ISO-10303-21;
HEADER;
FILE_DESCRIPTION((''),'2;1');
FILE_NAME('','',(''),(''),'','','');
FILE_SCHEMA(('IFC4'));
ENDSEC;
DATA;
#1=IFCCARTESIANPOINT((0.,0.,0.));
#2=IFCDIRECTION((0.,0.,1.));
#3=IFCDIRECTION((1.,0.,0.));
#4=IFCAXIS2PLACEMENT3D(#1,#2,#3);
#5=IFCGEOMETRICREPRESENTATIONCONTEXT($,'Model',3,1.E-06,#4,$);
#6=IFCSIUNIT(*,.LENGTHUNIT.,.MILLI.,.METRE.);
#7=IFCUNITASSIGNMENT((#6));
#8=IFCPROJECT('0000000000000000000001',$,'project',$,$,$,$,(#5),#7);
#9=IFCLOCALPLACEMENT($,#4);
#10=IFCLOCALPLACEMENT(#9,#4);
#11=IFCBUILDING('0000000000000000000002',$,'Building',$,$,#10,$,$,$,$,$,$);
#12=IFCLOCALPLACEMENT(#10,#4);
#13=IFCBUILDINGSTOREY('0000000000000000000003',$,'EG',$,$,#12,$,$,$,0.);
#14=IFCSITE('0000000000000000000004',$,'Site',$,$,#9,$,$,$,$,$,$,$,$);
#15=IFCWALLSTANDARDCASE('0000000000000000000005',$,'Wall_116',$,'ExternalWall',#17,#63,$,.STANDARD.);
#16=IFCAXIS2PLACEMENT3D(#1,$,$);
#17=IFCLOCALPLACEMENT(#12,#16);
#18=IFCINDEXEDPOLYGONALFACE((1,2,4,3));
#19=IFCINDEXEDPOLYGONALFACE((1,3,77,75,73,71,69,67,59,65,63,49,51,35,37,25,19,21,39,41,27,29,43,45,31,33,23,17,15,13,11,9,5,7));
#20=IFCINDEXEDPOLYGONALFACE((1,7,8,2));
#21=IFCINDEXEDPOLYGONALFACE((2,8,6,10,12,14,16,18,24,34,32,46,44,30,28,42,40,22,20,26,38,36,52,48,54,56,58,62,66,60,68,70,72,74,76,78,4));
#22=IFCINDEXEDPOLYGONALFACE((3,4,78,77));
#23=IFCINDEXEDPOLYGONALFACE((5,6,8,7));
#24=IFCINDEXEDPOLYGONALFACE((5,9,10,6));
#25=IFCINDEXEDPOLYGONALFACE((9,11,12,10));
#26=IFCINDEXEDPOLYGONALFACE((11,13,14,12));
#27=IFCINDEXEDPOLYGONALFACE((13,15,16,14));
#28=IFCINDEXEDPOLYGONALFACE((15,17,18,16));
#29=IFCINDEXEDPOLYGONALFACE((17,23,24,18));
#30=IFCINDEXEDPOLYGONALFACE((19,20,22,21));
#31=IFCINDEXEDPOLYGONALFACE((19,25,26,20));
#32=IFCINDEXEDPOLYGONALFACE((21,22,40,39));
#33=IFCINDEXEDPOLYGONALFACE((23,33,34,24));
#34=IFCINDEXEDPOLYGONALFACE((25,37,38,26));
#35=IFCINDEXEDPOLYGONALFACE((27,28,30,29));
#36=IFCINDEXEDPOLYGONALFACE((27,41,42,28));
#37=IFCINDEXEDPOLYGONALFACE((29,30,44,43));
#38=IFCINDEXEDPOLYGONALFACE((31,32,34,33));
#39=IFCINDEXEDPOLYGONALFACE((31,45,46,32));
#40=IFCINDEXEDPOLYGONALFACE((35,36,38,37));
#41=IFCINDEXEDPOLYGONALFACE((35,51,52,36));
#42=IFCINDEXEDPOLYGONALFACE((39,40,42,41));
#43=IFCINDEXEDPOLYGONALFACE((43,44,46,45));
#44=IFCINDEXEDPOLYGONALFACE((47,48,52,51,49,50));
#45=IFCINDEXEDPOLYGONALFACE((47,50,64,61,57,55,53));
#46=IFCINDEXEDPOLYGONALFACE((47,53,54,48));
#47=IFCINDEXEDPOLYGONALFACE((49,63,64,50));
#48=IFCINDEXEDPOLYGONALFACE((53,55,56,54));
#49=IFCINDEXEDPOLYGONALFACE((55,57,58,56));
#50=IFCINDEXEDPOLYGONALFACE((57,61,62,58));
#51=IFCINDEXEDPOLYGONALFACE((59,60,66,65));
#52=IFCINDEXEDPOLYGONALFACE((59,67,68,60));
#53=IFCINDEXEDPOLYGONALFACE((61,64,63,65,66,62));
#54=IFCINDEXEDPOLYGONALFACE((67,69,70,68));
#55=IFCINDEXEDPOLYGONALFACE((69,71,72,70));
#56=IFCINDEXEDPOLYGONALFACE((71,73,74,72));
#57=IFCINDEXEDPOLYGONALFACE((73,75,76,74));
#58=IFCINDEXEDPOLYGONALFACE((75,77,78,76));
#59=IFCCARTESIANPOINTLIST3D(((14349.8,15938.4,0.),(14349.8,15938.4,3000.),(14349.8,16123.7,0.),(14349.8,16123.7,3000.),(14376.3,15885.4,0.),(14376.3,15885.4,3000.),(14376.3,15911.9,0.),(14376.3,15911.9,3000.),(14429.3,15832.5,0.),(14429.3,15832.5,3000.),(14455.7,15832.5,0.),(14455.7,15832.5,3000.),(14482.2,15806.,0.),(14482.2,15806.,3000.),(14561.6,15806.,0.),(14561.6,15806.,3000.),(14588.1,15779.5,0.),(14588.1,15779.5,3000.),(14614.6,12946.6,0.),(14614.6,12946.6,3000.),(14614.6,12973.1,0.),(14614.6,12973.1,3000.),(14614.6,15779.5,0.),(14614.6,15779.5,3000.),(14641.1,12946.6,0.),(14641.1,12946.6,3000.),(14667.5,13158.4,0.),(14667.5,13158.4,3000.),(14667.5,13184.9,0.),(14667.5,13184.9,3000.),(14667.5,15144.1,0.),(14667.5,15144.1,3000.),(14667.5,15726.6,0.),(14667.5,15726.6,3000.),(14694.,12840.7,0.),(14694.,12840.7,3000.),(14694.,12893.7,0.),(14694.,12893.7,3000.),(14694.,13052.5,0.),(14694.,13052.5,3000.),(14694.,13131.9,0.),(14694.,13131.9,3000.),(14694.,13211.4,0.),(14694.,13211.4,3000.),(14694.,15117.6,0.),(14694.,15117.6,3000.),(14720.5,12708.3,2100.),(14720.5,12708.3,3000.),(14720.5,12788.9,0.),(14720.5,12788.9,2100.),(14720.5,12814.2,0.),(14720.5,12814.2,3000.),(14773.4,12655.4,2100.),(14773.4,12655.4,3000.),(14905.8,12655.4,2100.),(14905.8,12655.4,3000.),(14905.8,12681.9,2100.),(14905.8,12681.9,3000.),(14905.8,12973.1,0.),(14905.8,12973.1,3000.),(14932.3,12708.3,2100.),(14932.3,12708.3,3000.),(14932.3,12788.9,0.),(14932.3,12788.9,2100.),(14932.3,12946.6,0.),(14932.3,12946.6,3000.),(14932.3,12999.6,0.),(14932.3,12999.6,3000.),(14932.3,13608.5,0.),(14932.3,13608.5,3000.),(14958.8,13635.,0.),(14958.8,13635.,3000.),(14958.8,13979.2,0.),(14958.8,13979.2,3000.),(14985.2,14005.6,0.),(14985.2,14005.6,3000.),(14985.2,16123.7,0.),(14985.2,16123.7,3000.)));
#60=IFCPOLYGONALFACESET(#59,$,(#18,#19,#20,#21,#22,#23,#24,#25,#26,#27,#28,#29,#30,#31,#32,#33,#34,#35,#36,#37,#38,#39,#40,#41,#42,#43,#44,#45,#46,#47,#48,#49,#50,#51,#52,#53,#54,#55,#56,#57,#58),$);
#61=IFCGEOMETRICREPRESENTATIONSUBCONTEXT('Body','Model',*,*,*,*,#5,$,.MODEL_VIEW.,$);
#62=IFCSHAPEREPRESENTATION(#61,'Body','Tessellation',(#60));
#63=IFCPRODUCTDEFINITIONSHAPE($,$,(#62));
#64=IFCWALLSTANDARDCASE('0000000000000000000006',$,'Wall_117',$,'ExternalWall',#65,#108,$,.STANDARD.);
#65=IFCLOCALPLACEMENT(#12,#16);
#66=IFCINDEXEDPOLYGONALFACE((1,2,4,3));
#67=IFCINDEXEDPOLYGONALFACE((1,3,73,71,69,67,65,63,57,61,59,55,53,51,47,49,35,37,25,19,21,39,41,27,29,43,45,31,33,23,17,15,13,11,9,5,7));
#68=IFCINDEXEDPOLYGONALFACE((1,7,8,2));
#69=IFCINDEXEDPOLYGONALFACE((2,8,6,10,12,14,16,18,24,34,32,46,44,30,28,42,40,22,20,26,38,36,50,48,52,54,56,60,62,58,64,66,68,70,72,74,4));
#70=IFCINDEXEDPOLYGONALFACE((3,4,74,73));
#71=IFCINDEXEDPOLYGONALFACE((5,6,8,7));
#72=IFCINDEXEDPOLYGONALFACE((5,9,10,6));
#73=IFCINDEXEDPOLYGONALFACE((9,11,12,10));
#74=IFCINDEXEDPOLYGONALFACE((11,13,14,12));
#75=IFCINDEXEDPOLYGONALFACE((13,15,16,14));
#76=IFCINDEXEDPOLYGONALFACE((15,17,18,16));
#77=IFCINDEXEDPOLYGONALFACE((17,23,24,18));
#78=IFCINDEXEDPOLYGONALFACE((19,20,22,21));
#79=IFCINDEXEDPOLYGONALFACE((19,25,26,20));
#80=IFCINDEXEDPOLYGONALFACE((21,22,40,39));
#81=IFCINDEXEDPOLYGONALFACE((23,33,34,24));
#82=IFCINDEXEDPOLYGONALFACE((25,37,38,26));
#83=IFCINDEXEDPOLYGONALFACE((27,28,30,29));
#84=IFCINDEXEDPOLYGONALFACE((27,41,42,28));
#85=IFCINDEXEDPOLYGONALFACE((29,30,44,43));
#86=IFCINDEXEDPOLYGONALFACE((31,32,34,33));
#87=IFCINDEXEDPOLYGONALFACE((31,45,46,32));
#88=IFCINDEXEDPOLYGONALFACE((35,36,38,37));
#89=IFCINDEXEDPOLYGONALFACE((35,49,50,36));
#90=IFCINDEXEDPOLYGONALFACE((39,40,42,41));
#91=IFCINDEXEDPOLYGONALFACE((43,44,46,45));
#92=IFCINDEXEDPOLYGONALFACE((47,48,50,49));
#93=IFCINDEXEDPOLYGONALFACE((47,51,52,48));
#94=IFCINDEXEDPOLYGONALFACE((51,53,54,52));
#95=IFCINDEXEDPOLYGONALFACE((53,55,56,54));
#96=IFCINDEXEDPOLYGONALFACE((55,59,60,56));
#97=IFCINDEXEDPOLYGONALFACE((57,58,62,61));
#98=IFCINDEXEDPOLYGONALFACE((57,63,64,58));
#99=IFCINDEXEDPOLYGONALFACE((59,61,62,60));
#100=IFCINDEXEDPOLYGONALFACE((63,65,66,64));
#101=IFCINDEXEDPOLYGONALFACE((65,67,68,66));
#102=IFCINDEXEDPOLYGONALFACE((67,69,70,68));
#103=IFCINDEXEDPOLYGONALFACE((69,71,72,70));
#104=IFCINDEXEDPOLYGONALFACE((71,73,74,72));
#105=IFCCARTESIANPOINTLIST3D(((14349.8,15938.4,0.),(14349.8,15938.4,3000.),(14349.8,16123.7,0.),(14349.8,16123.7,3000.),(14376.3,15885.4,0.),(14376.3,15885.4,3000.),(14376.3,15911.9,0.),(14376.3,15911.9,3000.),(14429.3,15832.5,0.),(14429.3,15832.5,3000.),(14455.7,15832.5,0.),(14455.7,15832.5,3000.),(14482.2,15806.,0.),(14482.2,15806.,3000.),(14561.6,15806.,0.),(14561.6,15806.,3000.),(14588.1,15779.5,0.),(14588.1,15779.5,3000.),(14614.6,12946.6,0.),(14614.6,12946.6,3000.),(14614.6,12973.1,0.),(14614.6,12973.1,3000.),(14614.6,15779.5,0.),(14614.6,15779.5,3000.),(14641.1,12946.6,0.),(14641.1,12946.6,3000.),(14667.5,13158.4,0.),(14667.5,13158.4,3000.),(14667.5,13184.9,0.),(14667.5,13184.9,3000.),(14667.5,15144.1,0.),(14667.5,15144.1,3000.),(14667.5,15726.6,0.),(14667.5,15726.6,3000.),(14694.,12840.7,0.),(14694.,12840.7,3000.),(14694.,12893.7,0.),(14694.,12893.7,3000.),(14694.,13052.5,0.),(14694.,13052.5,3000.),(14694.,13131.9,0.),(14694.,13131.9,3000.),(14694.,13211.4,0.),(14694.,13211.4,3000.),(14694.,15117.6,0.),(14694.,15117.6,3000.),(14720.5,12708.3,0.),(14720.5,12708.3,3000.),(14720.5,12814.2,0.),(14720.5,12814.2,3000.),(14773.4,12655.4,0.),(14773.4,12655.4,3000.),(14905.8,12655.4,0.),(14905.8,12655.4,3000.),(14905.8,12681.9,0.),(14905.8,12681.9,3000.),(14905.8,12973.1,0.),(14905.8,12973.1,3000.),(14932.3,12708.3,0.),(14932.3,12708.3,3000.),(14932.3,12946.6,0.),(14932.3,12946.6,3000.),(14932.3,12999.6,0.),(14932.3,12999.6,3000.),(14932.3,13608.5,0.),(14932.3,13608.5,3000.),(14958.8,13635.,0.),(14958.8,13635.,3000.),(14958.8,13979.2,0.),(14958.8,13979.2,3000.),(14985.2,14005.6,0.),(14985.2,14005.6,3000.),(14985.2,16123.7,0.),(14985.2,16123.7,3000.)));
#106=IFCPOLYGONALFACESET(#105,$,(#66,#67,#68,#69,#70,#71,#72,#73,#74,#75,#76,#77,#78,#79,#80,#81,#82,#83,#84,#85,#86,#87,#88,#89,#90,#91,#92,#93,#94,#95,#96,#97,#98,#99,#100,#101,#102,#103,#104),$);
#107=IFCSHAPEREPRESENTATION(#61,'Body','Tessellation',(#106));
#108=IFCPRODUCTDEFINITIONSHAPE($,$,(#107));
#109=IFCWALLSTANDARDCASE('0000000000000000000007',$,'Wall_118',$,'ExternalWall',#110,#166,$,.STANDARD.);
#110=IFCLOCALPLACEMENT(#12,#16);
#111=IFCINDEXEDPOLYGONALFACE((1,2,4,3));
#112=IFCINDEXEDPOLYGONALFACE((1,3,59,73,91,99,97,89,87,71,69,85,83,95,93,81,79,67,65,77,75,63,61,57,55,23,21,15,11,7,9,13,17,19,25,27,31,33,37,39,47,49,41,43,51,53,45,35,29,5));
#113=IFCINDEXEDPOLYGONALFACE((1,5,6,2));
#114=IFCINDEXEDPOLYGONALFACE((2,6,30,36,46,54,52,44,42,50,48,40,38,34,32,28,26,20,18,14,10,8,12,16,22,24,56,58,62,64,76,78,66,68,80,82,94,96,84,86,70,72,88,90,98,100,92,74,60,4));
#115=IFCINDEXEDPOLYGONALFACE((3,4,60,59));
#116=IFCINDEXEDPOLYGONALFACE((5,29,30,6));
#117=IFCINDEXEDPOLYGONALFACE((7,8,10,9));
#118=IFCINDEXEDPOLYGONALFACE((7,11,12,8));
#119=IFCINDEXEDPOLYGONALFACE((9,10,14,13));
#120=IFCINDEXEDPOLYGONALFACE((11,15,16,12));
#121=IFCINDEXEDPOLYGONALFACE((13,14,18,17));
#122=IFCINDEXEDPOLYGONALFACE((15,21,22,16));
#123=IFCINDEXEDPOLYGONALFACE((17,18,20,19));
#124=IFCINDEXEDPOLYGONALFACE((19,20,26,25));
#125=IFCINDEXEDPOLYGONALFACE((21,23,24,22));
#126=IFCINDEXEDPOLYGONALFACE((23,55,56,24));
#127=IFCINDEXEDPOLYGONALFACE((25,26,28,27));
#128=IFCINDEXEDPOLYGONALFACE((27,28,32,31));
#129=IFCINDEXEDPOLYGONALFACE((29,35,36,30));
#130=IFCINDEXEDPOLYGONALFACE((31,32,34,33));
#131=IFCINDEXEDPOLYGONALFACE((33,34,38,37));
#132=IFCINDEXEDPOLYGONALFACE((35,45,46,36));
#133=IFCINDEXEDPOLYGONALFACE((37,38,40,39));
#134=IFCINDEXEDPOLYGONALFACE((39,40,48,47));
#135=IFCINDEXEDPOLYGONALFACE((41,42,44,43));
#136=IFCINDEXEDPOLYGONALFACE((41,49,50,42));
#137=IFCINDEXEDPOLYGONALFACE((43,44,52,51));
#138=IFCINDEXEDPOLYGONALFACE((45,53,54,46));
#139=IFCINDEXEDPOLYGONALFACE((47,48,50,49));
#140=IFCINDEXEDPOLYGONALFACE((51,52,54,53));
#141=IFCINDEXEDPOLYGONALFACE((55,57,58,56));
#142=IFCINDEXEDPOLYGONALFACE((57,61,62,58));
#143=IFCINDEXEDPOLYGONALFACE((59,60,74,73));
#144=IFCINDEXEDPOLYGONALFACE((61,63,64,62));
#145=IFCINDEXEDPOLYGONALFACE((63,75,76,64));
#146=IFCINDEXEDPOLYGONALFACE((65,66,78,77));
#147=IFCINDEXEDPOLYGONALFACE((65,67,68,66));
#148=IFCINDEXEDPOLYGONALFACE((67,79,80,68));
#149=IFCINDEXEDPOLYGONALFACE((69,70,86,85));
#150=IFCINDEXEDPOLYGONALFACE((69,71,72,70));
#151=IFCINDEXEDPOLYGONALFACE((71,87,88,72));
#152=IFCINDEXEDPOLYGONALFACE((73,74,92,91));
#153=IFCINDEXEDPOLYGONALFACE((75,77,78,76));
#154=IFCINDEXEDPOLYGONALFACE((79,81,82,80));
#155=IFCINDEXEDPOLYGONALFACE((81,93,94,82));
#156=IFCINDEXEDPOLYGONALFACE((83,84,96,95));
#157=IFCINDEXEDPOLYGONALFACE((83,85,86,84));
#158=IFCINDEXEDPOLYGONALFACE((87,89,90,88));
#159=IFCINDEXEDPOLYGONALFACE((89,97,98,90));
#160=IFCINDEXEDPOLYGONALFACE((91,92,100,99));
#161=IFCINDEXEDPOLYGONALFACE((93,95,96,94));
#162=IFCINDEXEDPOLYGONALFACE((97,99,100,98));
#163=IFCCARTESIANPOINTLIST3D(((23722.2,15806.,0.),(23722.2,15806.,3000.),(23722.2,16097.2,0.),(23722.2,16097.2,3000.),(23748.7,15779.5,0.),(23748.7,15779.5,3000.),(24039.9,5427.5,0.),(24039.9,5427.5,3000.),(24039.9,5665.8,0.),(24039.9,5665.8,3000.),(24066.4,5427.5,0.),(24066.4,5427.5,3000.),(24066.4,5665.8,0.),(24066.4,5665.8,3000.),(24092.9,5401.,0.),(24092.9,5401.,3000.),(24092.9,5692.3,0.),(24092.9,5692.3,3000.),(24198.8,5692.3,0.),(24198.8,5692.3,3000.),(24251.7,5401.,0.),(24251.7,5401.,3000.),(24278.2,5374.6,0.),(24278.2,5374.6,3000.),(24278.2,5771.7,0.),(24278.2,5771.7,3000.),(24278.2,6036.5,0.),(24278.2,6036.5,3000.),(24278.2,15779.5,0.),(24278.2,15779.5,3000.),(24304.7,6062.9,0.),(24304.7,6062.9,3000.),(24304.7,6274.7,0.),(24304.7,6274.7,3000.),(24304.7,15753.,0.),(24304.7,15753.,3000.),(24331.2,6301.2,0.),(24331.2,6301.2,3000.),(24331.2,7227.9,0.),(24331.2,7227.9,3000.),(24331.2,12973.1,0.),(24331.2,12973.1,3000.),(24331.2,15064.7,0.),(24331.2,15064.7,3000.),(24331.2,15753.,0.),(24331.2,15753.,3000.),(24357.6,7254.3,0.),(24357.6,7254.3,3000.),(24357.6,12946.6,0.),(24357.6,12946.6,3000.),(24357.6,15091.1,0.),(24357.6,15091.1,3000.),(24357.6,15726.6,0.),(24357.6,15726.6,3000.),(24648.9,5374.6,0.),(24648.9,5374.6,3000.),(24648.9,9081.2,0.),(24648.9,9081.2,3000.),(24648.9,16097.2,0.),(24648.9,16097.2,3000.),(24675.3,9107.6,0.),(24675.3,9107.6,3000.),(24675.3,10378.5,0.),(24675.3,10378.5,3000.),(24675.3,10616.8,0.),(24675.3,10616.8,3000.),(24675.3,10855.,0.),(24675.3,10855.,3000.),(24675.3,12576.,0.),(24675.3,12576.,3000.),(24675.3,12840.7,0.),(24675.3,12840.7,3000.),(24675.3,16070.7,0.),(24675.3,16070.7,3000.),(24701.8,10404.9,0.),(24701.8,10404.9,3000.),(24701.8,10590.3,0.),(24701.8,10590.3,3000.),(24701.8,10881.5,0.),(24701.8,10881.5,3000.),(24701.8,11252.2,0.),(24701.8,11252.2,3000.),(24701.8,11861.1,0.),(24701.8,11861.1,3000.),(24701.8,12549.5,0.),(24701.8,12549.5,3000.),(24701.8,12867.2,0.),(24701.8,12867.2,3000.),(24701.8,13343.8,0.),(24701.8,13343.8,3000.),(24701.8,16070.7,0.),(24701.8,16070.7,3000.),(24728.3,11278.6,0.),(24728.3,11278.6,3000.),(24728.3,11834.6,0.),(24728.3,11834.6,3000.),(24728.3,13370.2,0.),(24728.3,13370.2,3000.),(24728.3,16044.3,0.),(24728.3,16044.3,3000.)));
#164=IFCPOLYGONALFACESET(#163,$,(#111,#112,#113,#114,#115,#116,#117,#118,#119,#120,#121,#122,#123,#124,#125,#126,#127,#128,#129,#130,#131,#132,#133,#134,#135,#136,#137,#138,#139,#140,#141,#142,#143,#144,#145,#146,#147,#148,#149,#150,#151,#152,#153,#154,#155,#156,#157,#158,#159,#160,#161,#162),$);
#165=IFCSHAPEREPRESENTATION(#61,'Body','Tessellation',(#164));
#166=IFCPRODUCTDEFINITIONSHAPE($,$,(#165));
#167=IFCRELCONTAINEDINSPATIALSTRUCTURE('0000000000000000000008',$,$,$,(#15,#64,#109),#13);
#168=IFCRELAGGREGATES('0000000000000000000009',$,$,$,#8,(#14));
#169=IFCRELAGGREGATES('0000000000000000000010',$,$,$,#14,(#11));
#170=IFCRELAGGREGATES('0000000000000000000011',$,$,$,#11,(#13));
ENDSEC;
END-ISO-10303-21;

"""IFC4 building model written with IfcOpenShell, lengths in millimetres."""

from ifc_helpers import new_model, si_unit, frame, origin_with_axes, place, context, subcontext, project, spatial, polyline, rectangle, outline, extrude, element, save


model = new_model("IFC4")

# Units and contexts
model_context = context("Model", 3, precision=1e-06, world=origin_with_axes())
body_context = subcontext(model_context, "Body", "Model", "MODEL_VIEW")
ifc_project = project(units=[si_unit("LENGTHUNIT", "METRE", prefix="MILLI")], contexts=[model_context])

# Site, building, storey
site_placement = place(None, origin_with_axes())
site = spatial("IfcSite", under=ifc_project, at=site_placement, Name="Site")
building_placement = place(site_placement, origin_with_axes())
building = spatial("IfcBuilding", under=site, at=building_placement, Name="Building")
storey_placement = place(building_placement, origin_with_axes())
storey = spatial("IfcBuildingStorey", under=building, at=storey_placement, Name="EG", Elevation=0.0)

# Wall, opening
wall_1_placement = place(storey_placement, origin_with_axes())
wall_1 = element("IfcWallStandardCase", 1, at=wall_1_placement, inside=storey, Name="Wall_116", ObjectType="ExternalWall", PredefinedType="STANDARD", context=body_context, shape_type="SweptSolid", body=[
    extrude(outline(polyline([(14773.4, 12655.4, 0.0), (14720.5, 12708.3, 0.0), (14720.5, 12814.2, 0.0), (14694.0, 12840.7, 0.0), (14694.0, 12893.7, 0.0), (14641.1, 12946.6, 0.0), (14614.6, 12946.6, 0.0), (14614.6, 12973.1, 0.0), (14694.0, 13052.5, 0.0), (14694.0, 13131.9, 0.0), (14667.5, 13158.4, 0.0), (14667.5, 13184.9, 0.0), (14694.0, 13211.4, 0.0), (14694.0, 15117.6, 0.0), (14667.5, 15144.1, 0.0), (14667.5, 15726.6, 0.0), (14614.6, 15779.5, 0.0), (14588.1, 15779.5, 0.0), (14561.6, 15806.0, 0.0), (14482.2, 15806.0, 0.0), (14455.7, 15832.5, 0.0), (14429.3, 15832.5, 0.0), (14376.3, 15885.4, 0.0), (14376.3, 15911.9, 0.0), (14349.8, 15938.4, 0.0), (14349.8, 16123.7, 0.0), (14985.2, 16123.7, 0.0), (14985.2, 14005.6, 0.0), (14958.8, 13979.2, 0.0), (14958.8, 13635.0, 0.0), (14932.3, 13608.5, 0.0), (14932.3, 12999.6, 0.0), (14905.8, 12973.1, 0.0), (14932.3, 12946.6, 0.0), (14932.3, 12708.3, 0.0), (14905.8, 12681.9, 0.0), (14905.8, 12655.4, 0.0), (14773.4, 12655.4, 0.0)])), origin_with_axes(), (0.0, 0.0, 1.0), 3000.0),
])
opening_1_placement = place(wall_1_placement, origin_with_axes())
element("IfcOpeningElement", 2, at=opening_1_placement, inside=storey, cuts=wall_1, context=body_context, shape_type="SweptSolid", body=[
    extrude(rectangle(XDim=1059.0, YDim=144.9), frame((14827.6, 12716.5, 0.0), z_axis=(0.0, 0.0, 1.0), x_axis=(1.0, 0.0, 0.0)), (0.0, 0.0, 1.0), 2100.0),
])

# Walls
wall_2_placement = place(storey_placement, origin_with_axes())
element("IfcWallStandardCase", 3, at=wall_2_placement, inside=storey, Name="Wall_117", ObjectType="ExternalWall", PredefinedType="STANDARD", context=body_context, shape_type="SweptSolid", body=[
    extrude(outline(polyline([(14773.4, 12655.4, 0.0), (14720.5, 12708.3, 0.0), (14720.5, 12814.2, 0.0), (14694.0, 12840.7, 0.0), (14694.0, 12893.7, 0.0), (14641.1, 12946.6, 0.0), (14614.6, 12946.6, 0.0), (14614.6, 12973.1, 0.0), (14694.0, 13052.5, 0.0), (14694.0, 13131.9, 0.0), (14667.5, 13158.4, 0.0), (14667.5, 13184.9, 0.0), (14694.0, 13211.4, 0.0), (14694.0, 15117.6, 0.0), (14667.5, 15144.1, 0.0), (14667.5, 15726.6, 0.0), (14614.6, 15779.5, 0.0), (14588.1, 15779.5, 0.0), (14561.6, 15806.0, 0.0), (14482.2, 15806.0, 0.0), (14455.7, 15832.5, 0.0), (14429.3, 15832.5, 0.0), (14376.3, 15885.4, 0.0), (14376.3, 15911.9, 0.0), (14349.8, 15938.4, 0.0), (14349.8, 16123.7, 0.0), (14985.2, 16123.7, 0.0), (14985.2, 14005.6, 0.0), (14958.8, 13979.2, 0.0), (14958.8, 13635.0, 0.0), (14932.3, 13608.5, 0.0), (14932.3, 12999.6, 0.0), (14905.8, 12973.1, 0.0), (14932.3, 12946.6, 0.0), (14932.3, 12708.3, 0.0), (14905.8, 12681.9, 0.0), (14905.8, 12655.4, 0.0), (14773.4, 12655.4, 0.0)])), origin_with_axes(), (0.0, 0.0, 1.0), 3000.0),
])
wall_3_placement = place(storey_placement, origin_with_axes())
element("IfcWallStandardCase", 4, at=wall_3_placement, inside=storey, Name="Wall_118", ObjectType="ExternalWall", PredefinedType="STANDARD", context=body_context, shape_type="SweptSolid", body=[
    extrude(outline(polyline([(24278.2, 5374.6, 0.0), (24251.7, 5401.0, 0.0), (24092.9, 5401.0, 0.0), (24066.4, 5427.5, 0.0), (24039.9, 5427.5, 0.0), (24039.9, 5665.8, 0.0), (24066.4, 5665.8, 0.0), (24092.9, 5692.3, 0.0), (24198.8, 5692.3, 0.0), (24278.2, 5771.7, 0.0), (24278.2, 6036.5, 0.0), (24304.7, 6062.9, 0.0), (24304.7, 6274.7, 0.0), (24331.2, 6301.2, 0.0), (24331.2, 7227.9, 0.0), (24357.6, 7254.3, 0.0), (24357.6, 12946.6, 0.0), (24331.2, 12973.1, 0.0), (24331.2, 15064.7, 0.0), (24357.6, 15091.1, 0.0), (24357.6, 15726.6, 0.0), (24331.2, 15753.0, 0.0), (24304.7, 15753.0, 0.0), (24278.2, 15779.5, 0.0), (23748.7, 15779.5, 0.0), (23722.2, 15806.0, 0.0), (23722.2, 16097.2, 0.0), (24648.9, 16097.2, 0.0), (24675.3, 16070.7, 0.0), (24701.8, 16070.7, 0.0), (24728.3, 16044.3, 0.0), (24728.3, 13370.2, 0.0), (24701.8, 13343.8, 0.0), (24701.8, 12867.2, 0.0), (24675.3, 12840.7, 0.0), (24675.3, 12576.0, 0.0), (24701.8, 12549.5, 0.0), (24701.8, 11861.1, 0.0), (24728.3, 11834.6, 0.0), (24728.3, 11278.6, 0.0), (24701.8, 11252.2, 0.0), (24701.8, 10881.5, 0.0), (24675.3, 10855.0, 0.0), (24675.3, 10616.8, 0.0), (24701.8, 10590.3, 0.0), (24701.8, 10404.9, 0.0), (24675.3, 10378.5, 0.0), (24675.3, 9107.6, 0.0), (24648.9, 9081.2, 0.0), (24648.9, 5374.6, 0.0), (24278.2, 5374.6, 0.0)])), origin_with_axes(), (0.0, 0.0, 1.0), 3000.0),
])

save(model, "model.ifc")
